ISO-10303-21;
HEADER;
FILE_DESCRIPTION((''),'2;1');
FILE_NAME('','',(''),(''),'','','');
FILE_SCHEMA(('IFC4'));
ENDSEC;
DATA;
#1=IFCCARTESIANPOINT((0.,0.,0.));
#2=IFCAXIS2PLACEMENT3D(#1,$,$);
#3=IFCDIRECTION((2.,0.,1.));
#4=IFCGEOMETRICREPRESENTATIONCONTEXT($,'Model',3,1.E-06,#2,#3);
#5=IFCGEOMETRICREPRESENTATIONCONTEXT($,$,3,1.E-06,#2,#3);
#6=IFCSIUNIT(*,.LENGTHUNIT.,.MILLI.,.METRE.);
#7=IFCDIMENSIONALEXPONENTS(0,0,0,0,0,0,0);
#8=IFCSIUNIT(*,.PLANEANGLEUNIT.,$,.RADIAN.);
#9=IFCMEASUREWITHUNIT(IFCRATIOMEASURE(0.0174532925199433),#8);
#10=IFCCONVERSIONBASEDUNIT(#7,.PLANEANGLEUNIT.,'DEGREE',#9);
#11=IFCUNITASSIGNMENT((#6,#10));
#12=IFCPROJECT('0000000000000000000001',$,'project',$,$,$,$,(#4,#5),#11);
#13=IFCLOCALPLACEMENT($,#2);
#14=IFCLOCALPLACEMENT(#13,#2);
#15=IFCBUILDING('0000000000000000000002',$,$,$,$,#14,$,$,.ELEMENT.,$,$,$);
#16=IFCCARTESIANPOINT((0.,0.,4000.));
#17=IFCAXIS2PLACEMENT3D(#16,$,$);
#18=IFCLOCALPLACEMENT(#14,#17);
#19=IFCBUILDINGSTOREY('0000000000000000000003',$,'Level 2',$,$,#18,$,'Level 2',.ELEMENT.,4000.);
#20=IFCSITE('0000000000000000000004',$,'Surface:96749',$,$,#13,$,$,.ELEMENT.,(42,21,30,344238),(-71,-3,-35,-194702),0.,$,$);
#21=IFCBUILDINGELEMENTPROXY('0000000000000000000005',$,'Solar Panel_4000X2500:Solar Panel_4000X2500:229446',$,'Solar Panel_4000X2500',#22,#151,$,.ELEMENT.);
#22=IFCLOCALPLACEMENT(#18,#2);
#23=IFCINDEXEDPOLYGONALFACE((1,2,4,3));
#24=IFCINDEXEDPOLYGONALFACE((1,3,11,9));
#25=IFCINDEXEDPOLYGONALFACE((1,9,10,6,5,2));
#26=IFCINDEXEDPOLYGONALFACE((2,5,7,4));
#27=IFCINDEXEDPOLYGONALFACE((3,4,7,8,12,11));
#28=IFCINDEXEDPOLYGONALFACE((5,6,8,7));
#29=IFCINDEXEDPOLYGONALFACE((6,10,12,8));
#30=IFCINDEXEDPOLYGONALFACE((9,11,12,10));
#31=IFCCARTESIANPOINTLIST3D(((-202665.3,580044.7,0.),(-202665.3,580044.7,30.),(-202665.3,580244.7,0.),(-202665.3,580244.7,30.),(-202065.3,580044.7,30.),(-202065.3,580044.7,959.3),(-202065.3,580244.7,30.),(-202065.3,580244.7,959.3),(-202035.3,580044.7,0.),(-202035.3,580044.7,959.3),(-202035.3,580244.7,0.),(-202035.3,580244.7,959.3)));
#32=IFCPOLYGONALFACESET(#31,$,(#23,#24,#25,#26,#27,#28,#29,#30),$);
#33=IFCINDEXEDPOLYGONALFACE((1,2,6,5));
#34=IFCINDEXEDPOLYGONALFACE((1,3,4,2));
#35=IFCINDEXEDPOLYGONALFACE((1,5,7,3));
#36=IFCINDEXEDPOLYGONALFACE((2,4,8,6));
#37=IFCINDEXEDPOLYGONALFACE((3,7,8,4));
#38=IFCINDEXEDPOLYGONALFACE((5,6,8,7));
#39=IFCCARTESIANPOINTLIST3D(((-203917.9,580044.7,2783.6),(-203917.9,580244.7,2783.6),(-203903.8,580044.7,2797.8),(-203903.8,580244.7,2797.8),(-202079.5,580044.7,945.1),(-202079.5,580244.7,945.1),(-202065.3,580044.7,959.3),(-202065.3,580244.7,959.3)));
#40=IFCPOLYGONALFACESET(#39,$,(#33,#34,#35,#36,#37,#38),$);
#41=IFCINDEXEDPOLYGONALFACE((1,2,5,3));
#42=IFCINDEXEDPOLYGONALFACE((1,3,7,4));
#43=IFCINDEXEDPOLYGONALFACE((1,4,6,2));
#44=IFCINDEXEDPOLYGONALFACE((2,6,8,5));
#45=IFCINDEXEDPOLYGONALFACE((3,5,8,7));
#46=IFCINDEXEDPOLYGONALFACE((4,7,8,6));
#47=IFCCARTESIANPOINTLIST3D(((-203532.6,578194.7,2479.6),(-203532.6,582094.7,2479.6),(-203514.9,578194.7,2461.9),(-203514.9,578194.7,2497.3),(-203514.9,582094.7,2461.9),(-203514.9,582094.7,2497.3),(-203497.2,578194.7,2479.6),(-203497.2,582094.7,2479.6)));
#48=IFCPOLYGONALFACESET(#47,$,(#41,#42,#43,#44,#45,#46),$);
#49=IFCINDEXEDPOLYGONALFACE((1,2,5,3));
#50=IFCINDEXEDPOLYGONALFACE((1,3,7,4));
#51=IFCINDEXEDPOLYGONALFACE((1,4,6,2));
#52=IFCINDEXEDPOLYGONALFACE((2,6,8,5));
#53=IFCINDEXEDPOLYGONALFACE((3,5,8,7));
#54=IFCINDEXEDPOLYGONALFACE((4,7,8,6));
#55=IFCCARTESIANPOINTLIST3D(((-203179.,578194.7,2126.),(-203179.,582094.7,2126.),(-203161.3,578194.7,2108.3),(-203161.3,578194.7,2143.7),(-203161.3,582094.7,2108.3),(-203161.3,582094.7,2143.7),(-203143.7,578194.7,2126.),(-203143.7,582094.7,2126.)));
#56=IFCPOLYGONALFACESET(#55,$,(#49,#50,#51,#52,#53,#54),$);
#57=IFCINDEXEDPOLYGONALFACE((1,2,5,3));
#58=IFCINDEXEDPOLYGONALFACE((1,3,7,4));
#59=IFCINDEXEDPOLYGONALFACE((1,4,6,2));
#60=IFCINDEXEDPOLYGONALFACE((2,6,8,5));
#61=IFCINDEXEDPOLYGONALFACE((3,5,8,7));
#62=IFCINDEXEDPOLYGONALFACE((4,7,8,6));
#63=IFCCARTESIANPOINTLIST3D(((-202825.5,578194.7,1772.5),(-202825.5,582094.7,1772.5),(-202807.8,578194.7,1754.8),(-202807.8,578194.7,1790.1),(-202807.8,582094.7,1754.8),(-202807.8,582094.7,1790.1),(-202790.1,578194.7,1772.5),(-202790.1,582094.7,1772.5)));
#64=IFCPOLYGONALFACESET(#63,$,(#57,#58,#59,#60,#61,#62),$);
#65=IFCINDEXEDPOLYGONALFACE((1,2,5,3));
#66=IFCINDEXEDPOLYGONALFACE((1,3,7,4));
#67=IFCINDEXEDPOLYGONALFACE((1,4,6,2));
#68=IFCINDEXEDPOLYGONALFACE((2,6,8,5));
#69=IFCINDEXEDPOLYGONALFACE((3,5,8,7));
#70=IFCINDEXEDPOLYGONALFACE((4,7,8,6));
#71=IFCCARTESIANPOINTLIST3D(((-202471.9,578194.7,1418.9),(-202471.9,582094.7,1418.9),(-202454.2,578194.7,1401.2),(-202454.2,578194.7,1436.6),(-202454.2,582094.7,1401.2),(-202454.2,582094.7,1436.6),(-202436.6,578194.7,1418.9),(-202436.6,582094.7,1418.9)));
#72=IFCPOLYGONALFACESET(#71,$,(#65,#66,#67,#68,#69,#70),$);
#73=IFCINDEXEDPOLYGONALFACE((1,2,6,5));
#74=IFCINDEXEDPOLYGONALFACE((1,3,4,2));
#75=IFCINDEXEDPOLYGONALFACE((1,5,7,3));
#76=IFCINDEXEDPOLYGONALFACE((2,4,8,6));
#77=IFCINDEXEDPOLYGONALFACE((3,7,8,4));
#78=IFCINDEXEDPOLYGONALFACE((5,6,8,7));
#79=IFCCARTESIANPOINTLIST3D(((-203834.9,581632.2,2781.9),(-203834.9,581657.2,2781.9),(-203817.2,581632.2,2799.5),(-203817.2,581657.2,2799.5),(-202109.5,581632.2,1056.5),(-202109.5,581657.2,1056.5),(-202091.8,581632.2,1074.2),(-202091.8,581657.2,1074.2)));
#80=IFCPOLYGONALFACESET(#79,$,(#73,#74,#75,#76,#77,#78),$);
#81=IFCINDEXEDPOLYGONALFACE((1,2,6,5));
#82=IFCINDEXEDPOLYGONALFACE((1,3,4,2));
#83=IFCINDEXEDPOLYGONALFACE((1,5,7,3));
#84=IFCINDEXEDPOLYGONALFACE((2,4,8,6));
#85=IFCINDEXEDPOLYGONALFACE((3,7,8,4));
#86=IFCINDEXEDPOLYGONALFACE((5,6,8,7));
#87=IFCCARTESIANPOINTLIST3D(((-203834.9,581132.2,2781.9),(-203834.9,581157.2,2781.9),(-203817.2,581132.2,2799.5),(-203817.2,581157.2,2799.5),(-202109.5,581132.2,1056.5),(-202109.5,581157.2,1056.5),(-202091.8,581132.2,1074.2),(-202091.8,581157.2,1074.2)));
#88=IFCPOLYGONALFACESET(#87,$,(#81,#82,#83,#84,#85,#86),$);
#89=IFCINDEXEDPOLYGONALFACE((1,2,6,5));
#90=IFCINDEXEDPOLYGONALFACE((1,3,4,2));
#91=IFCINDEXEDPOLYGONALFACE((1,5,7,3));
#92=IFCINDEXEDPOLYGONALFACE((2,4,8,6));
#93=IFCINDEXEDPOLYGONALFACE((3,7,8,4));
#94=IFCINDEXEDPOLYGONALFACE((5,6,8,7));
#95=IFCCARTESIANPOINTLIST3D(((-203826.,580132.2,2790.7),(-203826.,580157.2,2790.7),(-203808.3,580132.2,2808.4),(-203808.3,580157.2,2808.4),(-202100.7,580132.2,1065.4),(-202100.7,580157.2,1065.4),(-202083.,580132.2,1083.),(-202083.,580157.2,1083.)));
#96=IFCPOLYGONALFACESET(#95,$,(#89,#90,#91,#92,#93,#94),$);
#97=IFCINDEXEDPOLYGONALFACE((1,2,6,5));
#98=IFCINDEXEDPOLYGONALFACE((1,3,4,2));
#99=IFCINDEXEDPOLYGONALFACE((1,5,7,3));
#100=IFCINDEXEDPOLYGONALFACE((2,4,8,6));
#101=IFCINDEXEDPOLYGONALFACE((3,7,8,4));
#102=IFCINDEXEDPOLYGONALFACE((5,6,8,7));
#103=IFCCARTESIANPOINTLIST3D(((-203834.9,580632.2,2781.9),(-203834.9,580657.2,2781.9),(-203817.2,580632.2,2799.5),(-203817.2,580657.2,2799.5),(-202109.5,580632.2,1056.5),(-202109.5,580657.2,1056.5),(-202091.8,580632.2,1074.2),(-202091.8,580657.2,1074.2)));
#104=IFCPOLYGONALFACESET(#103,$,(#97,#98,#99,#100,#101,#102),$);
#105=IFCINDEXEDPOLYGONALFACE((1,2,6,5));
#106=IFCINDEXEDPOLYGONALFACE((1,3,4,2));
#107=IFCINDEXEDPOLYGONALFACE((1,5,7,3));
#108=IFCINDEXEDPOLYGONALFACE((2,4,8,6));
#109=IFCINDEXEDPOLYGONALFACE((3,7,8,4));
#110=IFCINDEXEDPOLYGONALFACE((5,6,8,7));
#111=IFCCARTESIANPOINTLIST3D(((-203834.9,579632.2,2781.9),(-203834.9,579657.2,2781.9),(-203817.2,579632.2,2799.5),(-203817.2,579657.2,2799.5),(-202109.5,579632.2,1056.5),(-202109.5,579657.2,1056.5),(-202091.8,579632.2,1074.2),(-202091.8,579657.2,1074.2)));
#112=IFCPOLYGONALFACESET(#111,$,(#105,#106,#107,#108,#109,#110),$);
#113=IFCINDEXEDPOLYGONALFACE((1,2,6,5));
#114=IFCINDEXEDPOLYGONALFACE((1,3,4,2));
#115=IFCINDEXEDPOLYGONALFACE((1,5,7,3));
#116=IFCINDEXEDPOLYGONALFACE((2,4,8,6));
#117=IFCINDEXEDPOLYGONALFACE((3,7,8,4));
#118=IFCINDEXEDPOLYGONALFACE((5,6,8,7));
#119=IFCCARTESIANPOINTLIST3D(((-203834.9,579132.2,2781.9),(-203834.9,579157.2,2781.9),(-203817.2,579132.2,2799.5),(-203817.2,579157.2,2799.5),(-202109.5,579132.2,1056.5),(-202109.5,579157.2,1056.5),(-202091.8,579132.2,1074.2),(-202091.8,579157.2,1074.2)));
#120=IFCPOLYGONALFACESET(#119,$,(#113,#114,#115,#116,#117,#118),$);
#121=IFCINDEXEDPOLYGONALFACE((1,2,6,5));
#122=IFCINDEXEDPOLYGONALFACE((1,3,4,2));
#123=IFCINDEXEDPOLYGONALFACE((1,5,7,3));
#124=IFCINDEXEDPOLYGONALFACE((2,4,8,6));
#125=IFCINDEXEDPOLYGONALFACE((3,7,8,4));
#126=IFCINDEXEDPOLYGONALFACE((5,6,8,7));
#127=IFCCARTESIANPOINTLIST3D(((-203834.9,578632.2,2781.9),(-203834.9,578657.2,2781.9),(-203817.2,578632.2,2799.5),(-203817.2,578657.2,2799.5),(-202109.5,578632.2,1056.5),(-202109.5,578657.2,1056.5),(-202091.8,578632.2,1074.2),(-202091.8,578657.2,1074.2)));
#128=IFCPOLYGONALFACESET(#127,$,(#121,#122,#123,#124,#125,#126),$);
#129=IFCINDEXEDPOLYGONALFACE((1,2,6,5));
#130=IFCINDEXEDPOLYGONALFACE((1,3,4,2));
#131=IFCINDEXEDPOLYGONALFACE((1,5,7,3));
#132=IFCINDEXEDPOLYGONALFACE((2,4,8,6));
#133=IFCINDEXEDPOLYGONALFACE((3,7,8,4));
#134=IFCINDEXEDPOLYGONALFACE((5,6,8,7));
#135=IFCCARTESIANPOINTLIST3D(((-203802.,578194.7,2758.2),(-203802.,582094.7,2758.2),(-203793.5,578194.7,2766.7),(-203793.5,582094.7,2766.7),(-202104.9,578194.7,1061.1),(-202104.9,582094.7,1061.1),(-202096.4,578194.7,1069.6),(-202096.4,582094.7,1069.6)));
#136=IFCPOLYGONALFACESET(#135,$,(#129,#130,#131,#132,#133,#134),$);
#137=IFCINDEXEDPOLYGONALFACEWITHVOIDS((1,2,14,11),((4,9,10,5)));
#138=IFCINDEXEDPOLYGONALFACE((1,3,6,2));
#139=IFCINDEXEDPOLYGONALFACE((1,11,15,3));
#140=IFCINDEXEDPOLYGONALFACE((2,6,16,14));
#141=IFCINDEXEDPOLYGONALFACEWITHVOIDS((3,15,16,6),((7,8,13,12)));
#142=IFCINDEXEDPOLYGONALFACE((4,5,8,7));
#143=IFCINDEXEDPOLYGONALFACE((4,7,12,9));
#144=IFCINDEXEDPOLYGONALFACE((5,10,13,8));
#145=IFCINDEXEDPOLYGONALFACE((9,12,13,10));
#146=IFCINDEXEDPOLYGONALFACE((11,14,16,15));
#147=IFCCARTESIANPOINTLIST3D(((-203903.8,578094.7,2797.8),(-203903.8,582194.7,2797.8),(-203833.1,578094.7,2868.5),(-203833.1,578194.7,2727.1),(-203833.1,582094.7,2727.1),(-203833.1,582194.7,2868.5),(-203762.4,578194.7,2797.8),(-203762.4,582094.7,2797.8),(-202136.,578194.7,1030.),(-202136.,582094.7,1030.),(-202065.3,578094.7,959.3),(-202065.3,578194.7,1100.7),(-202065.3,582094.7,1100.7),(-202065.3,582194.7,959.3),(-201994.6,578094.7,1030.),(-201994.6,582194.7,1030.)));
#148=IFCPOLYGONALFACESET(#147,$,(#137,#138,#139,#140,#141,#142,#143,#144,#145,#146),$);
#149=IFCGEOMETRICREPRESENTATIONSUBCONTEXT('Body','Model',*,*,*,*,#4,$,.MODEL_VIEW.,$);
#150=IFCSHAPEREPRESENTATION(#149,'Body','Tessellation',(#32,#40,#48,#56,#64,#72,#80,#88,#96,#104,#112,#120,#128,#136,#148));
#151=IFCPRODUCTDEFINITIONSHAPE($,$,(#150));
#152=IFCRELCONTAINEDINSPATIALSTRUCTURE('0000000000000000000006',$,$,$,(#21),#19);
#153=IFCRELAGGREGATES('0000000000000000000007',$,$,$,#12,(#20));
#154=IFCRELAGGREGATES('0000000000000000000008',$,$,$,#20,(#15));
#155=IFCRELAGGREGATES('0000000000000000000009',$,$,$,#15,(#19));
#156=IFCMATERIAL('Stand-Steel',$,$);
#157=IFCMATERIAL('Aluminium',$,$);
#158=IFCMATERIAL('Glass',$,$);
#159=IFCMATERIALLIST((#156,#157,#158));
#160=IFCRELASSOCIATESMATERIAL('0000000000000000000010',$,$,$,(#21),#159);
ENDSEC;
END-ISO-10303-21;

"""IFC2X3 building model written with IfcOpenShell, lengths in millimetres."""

from ifc_helpers import new_model, entity, si_unit, converted_unit, direction, frame, frame_2d, origin, origin_2d_with_axis, place, context, subcontext, project, spatial, polyline, rectangle, outline, extrude, source, transform, mapped, material, material_list, element, save


model = new_model("IFC2X3")

# Units and contexts
model_context = context("Model", 3, precision=1e-06, world=origin(), true_north=direction((2.0, 0.0, 1.0)))
context_of_model = context(None, 3, precision=1e-06, world=origin(), true_north=direction((2.0, 0.0, 1.0)))
body_context = subcontext(model_context, "Body", "Model", "MODEL_VIEW")
ifc_project = project(units=[si_unit("LENGTHUNIT", "METRE", prefix="MILLI"), converted_unit("PLANEANGLEUNIT", "DEGREE", entity("IfcRatioMeasure", 0.0174532925199433), si_unit("PLANEANGLEUNIT", "RADIAN"), dimensions=[0, 0, 0, 0, 0, 0, 0])], contexts=[model_context, context_of_model])

# Site, building, storey
site_placement = place(None, origin())
site = spatial("IfcSite", under=ifc_project, at=site_placement, Name="Surface:96749", CompositionType="ELEMENT", RefLatitude=(42, 21, 30, 344238), RefLongitude=(-71, -3, -35, -194702), RefElevation=0.0)
building_placement = place(site_placement, origin())
building = spatial("IfcBuilding", under=site, at=building_placement, CompositionType="ELEMENT")
storey_placement = place(building_placement, frame((0.0, 0.0, 4000.0)))
storey = spatial("IfcBuildingStorey", under=building, at=storey_placement, Name="Level 2", LongName="Level 2", CompositionType="ELEMENT", Elevation=4000.0)

# Building element proxy
ifc_material_1 = material(Name="Stand-Steel")
ifc_material_2 = material(Name="Aluminium")
ifc_material_3 = material(Name="Glass")
shared_shape = source(origin(), body_context, "Body", "SweptSolid", [
    extrude(outline(polyline([(-629.5, -220.0), (329.8, -220.0), (329.8, 410.0), (299.8, 410.0), (299.8, -190.0), (-629.5, -190.0), (-629.5, -220.0)])), frame((-190.0, -100.0, 299.8), z_axis=(0.0, 1.0, 0.0), x_axis=(0.0, 0.0, -1.0)), (0.0, 0.0, 1.0), 200.0),
    extrude(rectangle(XDim=20.0, YDim=200.0, at=frame_2d((0.0, 0.0), x_axis=(0.0, 1.0))), frame((-7.1, 0.0, 922.2), z_axis=(-0.707107, 0.0, 0.707107), x_axis=(0.0, 1.0, 0.0)), (0.0, 0.0, 1.0), 2600.0),
    extrude(rectangle(XDim=25.0, YDim=25.0, at=frame_2d((0.0, 0.0), x_axis=(1.0, 0.0))), frame((-1449.6, -1950.0, 2449.6), z_axis=(0.0, 1.0, 0.0), x_axis=(-0.707107, 0.0, -0.707107)), (0.0, 0.0, 1.0), 3900.0),
    extrude(rectangle(XDim=25.0, YDim=25.0, at=origin_2d_with_axis()), frame((-1096.0, -1950.0, 2096.0), z_axis=(0.0, 1.0, 0.0), x_axis=(-0.707107, 0.0, -0.707107)), (0.0, 0.0, 1.0), 3900.0),
    extrude(rectangle(XDim=25.0, YDim=25.0, at=origin_2d_with_axis()), frame((-742.5, -1950.0, 1742.5), z_axis=(0.0, 1.0, 0.0), x_axis=(-0.707107, 0.0, -0.707107)), (0.0, 0.0, 1.0), 3900.0),
    extrude(rectangle(XDim=25.0, YDim=25.0, at=frame_2d((0.0, 0.0), x_axis=(1.0, 0.0))), frame((-388.9, -1950.0, 1388.9), z_axis=(0.0, 1.0, 0.0), x_axis=(-0.707107, 0.0, -0.707107)), (0.0, 0.0, 1.0), 3900.0),
    extrude(rectangle(XDim=25.0, YDim=25.0, at=frame_2d((0.0, 0.0), x_axis=(0.0, 1.0))), frame((-35.4, 1500.0, 1035.4), z_axis=(-0.707107, 0.0, 0.707107), x_axis=(0.0, 1.0, 0.0)), (0.0, 0.0, 1.0), 2440.0),
    extrude(rectangle(XDim=25.0, YDim=25.0, at=frame_2d((0.0, 0.0), x_axis=(0.0, 1.0))), frame((-35.4, 1000.0, 1035.4), z_axis=(-0.707107, 0.0, 0.707107), x_axis=(0.0, 1.0, 0.0)), (0.0, 0.0, 1.0), 2440.0),
    extrude(rectangle(XDim=25.0, YDim=25.0, at=frame_2d((0.0, 0.0), x_axis=(0.0, 1.0))), frame((-26.5, 0.0, 1044.2), z_axis=(-0.707107, 0.0, 0.707107), x_axis=(0.0, -1.0, 0.0)), (0.0, 0.0, 1.0), 2440.0),
    extrude(rectangle(XDim=25.0, YDim=25.0, at=frame_2d((0.0, 0.0), x_axis=(0.0, 1.0))), frame((-35.4, 500.0, 1035.4), z_axis=(-0.707107, 0.0, 0.707107), x_axis=(0.0, 1.0, 0.0)), (0.0, 0.0, 1.0), 2440.0),
    extrude(rectangle(XDim=25.0, YDim=25.0, at=frame_2d((0.0, 0.0), x_axis=(0.0, 1.0))), frame((-35.4, -500.0, 1035.4), z_axis=(-0.707107, 0.0, 0.707107), x_axis=(0.0, 1.0, 0.0)), (0.0, 0.0, 1.0), 2440.0),
    extrude(rectangle(XDim=25.0, YDim=25.0, at=frame_2d((0.0, 0.0), x_axis=(0.0, 1.0))), frame((-35.4, -1000.0, 1035.4), z_axis=(-0.707107, 0.0, 0.707107), x_axis=(0.0, 1.0, 0.0)), (0.0, 0.0, 1.0), 2440.0),
    extrude(rectangle(XDim=25.0, YDim=25.0, at=frame_2d((0.0, 0.0), x_axis=(0.0, 1.0))), frame((-35.4, -1500.0, 1035.4), z_axis=(-0.707107, 0.0, 0.707107), x_axis=(0.0, 1.0, 0.0)), (0.0, 0.0, 1.0), 2440.0),
    extrude(rectangle(XDim=2400.0, YDim=12.0, at=frame_2d((0.0, 0.0), x_axis=(1.0, 0.0))), frame((-883.9, -1950.0, 1883.9), z_axis=(0.0, 1.0, 0.0), x_axis=(0.707107, 0.0, -0.707107)), (0.0, 0.0, 1.0), 3900.0),
    extrude(outline(polyline([(-2050.0, -1300.0), (2050.0, -1300.0), (2050.0, 1300.0), (-2050.0, 1300.0), (-2050.0, -1300.0)]), holes=[polyline([(1950.0, -1200.0), (-1950.0, -1200.0), (-1950.0, 1200.0), (1950.0, 1200.0), (1950.0, -1200.0)])]), frame((-919.2, 0.0, 1848.5), z_axis=(0.707107, 0.0, 0.707107), x_axis=(0.0, 1.0, 0.0)), (0.0, 0.0, 1.0), 100.0),
])
ifc_material_list_1 = material_list([ifc_material_1, ifc_material_2, ifc_material_3])
proxy_1_placement = place(storey_placement, frame((-202065.3, 580144.7, 30.0)))
element("IfcBuildingElementProxy", 1, at=proxy_1_placement, inside=storey, material=ifc_material_list_1, Name="Solar Panel_4000X2500:Solar Panel_4000X2500:229446", ObjectType="Solar Panel_4000X2500", CompositionType="ELEMENT", context=body_context, shape_type="MappedRepresentation", body=[
    mapped(shared_shape, transform((0.0, 0.0, 0.0), scale=1.0)),
])

save(model, "model.ifc")
